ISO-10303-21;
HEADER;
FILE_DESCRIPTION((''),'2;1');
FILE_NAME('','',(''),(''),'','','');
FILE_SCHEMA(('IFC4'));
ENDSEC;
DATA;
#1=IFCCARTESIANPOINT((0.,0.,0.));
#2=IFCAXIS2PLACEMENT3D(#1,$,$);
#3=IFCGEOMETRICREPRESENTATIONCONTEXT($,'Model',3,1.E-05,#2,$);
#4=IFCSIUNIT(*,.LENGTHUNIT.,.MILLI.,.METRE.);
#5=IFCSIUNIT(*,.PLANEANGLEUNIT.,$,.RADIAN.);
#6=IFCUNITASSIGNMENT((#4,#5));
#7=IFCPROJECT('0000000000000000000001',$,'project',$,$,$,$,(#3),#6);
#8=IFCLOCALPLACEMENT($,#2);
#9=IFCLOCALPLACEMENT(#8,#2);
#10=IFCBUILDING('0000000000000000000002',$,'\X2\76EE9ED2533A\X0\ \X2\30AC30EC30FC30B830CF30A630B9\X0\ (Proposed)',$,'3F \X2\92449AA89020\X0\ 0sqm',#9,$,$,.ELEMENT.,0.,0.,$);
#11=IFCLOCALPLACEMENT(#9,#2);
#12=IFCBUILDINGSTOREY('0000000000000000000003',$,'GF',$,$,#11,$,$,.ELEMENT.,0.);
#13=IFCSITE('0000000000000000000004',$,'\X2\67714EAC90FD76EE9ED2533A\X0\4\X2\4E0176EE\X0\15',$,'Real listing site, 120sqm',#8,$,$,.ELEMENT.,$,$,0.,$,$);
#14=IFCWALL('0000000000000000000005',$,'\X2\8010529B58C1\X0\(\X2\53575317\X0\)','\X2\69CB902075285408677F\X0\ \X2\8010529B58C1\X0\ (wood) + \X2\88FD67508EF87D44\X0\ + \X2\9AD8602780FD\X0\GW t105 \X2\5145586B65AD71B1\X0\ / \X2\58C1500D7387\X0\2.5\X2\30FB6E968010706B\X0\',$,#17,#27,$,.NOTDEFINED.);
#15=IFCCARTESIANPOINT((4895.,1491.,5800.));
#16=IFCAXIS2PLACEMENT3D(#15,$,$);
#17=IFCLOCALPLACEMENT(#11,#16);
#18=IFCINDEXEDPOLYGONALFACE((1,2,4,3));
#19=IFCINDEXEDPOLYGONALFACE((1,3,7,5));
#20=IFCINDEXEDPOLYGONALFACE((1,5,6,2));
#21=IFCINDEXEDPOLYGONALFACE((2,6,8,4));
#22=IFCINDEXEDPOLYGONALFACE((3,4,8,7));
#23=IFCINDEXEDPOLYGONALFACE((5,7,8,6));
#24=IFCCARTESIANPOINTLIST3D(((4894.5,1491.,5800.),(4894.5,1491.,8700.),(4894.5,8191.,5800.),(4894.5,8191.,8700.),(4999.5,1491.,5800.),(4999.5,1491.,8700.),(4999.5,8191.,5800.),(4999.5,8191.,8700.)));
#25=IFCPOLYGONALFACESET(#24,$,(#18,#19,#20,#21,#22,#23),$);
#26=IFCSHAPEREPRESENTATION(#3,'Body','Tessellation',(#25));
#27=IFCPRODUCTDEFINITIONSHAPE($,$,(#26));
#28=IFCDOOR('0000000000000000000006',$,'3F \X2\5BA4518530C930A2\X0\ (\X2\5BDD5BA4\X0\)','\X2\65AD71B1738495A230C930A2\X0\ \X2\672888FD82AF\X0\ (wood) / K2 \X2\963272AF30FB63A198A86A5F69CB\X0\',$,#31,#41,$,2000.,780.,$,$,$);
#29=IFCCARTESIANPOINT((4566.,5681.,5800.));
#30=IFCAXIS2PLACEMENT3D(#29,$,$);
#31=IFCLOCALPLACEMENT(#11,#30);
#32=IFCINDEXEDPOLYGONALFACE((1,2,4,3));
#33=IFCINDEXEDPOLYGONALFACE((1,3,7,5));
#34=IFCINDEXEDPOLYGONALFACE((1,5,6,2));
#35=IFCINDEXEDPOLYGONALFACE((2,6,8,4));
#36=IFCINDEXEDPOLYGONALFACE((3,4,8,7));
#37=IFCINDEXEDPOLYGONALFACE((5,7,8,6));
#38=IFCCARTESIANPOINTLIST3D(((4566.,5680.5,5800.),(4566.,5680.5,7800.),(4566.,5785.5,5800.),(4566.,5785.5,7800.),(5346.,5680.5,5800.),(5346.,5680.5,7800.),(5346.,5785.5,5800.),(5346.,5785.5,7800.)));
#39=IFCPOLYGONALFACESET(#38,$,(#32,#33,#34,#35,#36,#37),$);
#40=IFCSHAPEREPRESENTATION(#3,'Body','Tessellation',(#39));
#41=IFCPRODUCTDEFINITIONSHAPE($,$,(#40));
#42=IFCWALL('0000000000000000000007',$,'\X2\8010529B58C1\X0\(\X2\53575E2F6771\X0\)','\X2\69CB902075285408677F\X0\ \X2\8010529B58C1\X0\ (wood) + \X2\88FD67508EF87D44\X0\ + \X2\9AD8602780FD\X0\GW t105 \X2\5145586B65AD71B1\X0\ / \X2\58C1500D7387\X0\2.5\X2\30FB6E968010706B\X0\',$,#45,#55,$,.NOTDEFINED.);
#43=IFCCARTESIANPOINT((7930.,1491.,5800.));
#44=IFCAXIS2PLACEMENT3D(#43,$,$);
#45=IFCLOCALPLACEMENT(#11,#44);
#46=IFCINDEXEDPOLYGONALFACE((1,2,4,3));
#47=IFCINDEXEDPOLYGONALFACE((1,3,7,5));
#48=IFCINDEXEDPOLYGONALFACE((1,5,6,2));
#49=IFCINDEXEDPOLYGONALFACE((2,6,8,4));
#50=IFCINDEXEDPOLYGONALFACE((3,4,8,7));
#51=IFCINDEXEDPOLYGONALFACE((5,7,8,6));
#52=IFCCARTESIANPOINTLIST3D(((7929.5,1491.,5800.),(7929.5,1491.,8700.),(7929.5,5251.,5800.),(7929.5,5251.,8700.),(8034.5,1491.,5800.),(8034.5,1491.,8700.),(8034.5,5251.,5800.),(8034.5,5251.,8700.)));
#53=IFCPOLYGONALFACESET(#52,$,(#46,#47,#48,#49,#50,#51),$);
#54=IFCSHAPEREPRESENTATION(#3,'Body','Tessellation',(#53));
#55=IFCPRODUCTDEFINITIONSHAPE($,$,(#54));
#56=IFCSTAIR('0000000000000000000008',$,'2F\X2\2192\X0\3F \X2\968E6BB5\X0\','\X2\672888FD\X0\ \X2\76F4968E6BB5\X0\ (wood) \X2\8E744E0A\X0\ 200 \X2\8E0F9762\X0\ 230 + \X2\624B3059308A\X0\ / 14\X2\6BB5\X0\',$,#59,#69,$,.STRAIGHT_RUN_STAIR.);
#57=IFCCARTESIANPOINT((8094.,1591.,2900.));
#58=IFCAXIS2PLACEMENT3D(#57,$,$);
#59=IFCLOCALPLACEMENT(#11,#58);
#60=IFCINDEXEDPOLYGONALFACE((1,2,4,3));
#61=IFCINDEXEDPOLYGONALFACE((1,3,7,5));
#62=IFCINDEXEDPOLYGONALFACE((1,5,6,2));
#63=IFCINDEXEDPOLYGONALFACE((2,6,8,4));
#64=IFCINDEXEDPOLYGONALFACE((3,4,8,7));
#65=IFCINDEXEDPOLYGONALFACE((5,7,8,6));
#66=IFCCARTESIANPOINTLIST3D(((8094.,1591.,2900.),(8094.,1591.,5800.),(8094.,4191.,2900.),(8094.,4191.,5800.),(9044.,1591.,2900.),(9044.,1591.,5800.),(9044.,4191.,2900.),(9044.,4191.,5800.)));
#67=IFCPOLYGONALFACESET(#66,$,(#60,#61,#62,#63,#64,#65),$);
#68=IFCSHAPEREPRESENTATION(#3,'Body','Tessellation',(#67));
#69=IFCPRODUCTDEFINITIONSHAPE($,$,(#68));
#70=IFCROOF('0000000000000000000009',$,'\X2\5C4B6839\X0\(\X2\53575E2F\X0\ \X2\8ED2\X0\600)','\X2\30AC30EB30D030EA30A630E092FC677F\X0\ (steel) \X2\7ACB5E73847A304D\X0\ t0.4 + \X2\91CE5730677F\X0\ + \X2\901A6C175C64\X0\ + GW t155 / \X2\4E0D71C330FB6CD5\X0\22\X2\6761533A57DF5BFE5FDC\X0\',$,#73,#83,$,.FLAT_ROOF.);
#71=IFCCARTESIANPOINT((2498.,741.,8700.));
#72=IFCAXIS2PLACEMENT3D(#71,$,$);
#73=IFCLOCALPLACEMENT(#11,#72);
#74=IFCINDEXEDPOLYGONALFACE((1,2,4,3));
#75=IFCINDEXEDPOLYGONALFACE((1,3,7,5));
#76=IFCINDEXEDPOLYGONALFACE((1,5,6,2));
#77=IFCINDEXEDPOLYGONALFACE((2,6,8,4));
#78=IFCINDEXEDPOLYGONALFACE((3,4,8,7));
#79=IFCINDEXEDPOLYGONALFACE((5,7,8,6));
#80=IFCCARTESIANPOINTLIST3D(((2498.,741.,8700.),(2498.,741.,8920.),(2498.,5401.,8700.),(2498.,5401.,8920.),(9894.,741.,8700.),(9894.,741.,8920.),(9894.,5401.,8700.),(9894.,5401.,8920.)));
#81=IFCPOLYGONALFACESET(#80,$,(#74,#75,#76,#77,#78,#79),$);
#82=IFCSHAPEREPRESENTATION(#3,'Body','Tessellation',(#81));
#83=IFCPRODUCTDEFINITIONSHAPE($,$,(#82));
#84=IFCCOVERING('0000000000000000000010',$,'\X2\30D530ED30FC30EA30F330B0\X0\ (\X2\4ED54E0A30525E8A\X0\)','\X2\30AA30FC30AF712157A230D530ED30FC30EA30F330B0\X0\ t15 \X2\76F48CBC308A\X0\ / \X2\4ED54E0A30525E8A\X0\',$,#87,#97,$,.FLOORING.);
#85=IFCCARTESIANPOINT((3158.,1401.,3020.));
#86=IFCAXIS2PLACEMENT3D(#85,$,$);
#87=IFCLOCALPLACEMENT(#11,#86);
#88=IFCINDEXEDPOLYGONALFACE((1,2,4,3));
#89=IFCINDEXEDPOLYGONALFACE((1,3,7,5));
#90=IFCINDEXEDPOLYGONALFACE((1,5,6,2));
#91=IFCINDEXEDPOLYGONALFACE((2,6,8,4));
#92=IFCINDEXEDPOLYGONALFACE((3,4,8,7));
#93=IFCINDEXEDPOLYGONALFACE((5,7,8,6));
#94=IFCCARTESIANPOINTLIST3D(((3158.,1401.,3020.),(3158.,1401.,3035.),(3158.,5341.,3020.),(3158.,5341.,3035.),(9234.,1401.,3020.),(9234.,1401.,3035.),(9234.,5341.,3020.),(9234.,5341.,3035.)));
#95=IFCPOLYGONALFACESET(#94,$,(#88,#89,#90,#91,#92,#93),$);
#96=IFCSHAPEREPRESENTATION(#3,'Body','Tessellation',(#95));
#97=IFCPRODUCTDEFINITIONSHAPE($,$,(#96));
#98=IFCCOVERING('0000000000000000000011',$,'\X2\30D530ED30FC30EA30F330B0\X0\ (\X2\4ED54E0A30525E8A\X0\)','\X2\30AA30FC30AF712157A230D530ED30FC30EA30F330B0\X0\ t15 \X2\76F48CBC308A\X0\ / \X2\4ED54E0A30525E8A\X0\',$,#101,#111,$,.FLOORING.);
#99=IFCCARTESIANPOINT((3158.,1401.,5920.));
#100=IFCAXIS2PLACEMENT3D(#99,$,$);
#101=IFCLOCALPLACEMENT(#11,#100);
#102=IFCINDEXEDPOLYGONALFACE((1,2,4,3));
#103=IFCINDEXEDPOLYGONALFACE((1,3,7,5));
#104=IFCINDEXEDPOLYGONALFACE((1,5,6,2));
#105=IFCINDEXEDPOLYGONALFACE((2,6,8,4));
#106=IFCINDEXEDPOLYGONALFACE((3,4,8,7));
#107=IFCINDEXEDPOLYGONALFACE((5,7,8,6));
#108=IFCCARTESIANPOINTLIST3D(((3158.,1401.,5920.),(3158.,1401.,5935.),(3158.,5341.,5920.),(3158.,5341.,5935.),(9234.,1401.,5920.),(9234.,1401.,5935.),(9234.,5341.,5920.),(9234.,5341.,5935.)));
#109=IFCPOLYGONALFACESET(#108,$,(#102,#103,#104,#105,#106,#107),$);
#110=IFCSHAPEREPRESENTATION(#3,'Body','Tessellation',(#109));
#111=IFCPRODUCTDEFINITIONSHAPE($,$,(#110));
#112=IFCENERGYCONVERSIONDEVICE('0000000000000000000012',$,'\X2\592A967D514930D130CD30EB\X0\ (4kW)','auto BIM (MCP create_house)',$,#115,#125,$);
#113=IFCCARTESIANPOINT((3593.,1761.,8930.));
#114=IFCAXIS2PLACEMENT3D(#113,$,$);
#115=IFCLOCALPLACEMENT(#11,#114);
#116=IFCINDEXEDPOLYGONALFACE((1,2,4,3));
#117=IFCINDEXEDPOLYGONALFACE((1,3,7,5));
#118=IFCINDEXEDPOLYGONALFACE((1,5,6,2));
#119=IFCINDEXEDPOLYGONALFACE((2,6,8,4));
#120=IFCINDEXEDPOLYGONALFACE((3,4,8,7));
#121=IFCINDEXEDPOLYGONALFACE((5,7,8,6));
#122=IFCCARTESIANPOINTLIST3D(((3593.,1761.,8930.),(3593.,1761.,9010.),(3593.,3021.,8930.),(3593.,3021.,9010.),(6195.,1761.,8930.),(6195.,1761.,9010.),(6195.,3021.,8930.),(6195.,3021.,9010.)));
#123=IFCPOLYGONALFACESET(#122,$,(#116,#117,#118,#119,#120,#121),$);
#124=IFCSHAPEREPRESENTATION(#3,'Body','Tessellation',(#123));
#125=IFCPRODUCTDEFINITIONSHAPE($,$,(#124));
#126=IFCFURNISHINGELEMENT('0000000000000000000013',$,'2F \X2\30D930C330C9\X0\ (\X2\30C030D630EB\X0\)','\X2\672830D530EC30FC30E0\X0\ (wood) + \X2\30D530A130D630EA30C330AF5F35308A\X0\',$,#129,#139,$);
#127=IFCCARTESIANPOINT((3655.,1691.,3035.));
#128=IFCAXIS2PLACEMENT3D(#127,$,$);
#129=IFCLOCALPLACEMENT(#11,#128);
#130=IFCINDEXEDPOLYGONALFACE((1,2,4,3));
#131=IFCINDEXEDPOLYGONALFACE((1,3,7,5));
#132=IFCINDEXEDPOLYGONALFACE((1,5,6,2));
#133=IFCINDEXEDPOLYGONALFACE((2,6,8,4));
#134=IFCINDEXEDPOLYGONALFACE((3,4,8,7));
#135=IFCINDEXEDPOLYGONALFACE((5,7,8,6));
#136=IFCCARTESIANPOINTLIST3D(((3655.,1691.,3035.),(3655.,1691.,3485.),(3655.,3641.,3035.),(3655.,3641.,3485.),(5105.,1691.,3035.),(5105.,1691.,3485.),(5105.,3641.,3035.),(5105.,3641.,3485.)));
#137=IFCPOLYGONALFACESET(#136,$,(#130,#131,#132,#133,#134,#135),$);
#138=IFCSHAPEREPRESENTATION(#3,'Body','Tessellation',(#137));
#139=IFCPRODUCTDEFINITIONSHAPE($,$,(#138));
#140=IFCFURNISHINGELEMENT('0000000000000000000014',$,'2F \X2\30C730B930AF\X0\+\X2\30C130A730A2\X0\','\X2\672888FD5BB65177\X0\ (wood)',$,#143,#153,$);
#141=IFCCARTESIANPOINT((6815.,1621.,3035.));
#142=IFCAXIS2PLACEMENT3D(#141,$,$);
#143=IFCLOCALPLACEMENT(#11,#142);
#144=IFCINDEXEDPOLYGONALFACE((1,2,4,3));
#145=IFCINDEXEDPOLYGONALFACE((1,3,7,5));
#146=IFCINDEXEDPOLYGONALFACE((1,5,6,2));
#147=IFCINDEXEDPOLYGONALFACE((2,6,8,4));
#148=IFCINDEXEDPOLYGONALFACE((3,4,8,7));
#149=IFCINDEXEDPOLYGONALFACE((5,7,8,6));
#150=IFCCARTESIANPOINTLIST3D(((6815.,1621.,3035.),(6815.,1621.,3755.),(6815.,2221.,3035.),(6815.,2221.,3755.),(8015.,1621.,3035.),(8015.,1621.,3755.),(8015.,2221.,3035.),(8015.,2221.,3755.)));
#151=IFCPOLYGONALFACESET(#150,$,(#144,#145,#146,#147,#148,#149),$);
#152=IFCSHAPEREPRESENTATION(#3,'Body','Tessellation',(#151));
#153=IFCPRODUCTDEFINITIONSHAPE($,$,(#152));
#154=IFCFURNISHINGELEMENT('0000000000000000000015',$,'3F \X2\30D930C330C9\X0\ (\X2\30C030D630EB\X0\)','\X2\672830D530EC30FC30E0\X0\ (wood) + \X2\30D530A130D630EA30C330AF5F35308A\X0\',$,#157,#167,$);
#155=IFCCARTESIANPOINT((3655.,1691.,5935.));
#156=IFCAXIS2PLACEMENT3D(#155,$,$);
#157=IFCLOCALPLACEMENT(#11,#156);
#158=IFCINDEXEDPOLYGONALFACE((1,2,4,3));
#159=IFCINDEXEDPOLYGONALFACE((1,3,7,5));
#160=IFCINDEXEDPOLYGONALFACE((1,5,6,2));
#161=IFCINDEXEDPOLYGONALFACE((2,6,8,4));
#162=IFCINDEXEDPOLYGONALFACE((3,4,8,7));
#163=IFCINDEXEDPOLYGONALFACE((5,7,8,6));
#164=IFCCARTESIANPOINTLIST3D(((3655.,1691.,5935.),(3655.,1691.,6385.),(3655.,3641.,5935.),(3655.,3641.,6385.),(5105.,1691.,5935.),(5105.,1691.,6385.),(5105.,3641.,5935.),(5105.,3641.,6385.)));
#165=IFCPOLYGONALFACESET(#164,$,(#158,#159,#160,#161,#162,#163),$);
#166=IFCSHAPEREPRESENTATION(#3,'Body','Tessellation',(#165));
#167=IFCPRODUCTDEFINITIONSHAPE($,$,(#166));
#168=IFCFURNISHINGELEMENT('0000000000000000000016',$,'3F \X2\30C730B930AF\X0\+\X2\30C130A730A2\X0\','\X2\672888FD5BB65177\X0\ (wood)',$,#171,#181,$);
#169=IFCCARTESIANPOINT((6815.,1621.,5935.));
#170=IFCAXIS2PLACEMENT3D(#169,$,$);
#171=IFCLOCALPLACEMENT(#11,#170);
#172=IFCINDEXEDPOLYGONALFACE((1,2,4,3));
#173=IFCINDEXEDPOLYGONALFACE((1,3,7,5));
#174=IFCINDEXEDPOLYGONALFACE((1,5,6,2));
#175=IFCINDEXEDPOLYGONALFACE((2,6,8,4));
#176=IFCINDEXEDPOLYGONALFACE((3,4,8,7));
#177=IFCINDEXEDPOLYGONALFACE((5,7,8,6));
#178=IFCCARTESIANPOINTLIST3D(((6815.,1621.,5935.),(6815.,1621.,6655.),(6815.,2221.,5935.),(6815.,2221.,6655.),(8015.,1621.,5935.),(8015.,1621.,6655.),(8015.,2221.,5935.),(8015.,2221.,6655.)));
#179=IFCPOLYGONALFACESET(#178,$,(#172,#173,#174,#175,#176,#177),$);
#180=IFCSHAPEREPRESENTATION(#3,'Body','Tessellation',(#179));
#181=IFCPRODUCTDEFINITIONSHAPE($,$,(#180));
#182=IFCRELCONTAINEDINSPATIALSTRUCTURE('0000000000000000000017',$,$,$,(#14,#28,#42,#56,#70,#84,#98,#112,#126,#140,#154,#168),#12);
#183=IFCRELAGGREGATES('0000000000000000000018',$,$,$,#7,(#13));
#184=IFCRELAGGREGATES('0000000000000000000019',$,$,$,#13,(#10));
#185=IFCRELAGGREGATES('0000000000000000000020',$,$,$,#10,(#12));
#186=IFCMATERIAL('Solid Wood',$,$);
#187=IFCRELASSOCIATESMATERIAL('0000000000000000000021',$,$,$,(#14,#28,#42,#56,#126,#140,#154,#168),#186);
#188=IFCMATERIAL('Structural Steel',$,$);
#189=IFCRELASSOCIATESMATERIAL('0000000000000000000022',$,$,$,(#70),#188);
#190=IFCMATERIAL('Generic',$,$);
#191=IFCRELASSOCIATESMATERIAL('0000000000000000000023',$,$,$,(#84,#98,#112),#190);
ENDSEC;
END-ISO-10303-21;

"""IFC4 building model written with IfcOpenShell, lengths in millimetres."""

from ifc_helpers import new_model, si_unit, frame, frame_2d, origin, place, context, project, spatial, rectangle, extrude, material, element, fill, save


model = new_model("IFC4")

# Units and contexts
model_context = context("Model", 3, precision=1e-05, world=origin())
ifc_project = project(units=[si_unit("LENGTHUNIT", "METRE", prefix="MILLI"), si_unit("PLANEANGLEUNIT", "RADIAN")], contexts=[model_context])

# Site, building, storey
site_placement = place(None, origin())
site = spatial("IfcSite", under=ifc_project, at=site_placement, Name="東京都目黒区4丁目15", ObjectType="Real listing site, 120sqm", CompositionType="ELEMENT", RefElevation=0.0)
building_placement = place(site_placement, origin())
building = spatial("IfcBuilding", under=site, at=building_placement, Name="目黒区 ガレージハウス (Proposed)", ObjectType="3F 鉄骨造 0sqm", CompositionType="ELEMENT", ElevationOfRefHeight=0.0, ElevationOfTerrain=0.0)
storey_placement = place(building_placement, origin())
storey = spatial("IfcBuildingStorey", under=building, at=storey_placement, Name="GF", CompositionType="ELEMENT", Elevation=0.0)

# Shared definitions
ifc_material_1 = material(Name="Solid Wood")

# Wall, opening, door
wall_1_placement = place(storey_placement, frame((4895.0, 1491.0, 5800.0)))
wall_1 = element("IfcWall", 1, at=wall_1_placement, inside=storey, material=ifc_material_1, Name="耐力壁(南北)", Description="構造用合板 耐力壁 (wood) + 製材軸組 + 高性能GW t105 充填断熱 / 壁倍率2.5・準耐火", PredefinedType="NOTDEFINED", context=model_context, shape_type="SweptSolid", body=[
    extrude(rectangle(XDim=105.0, YDim=6700.0, at=frame_2d((52.0, 3350.0))), frame((4895.0, 1491.0, 5800.0)), (0.0, 0.0, 1.0), 2900.0),
])
opening_1_placement = place(storey_placement, frame((4566.0, 5681.0, 5800.0)))
opening_1 = element("IfcOpeningElement", 2, at=opening_1_placement, cuts=wall_1, PredefinedType="NOTDEFINED", context=model_context, shape_type="SweptSolid", body=[
    extrude(rectangle(XDim=780.0, YDim=105.0, at=frame_2d((390.0, 52.0))), frame((4566.0, 5681.0, 5800.0)), (0.0, 0.0, 1.0), 2000.0),
])
door_1_placement = place(storey_placement, frame((4566.0, 5681.0, 5800.0)))
door_1 = element("IfcDoor", 3, at=door_1_placement, inside=storey, material=ifc_material_1, Name="3F 室内ドア (寝室)", Description="断熱玄関ドア 木製芯 (wood) / K2 防犯・採風機構", OverallHeight=2000.0, OverallWidth=780.0, context=model_context, shape_type="SweptSolid", body=[
    extrude(rectangle(XDim=780.0, YDim=105.0, at=frame_2d((390.0, 52.0))), frame((4566.0, 5681.0, 5800.0)), (0.0, 0.0, 1.0), 2000.0),
])
fill(opening_1, door_1)

# Wall
wall_2_placement = place(storey_placement, frame((7930.0, 1491.0, 5800.0)))
element("IfcWall", 4, at=wall_2_placement, inside=storey, material=ifc_material_1, Name="耐力壁(南帯東)", Description="構造用合板 耐力壁 (wood) + 製材軸組 + 高性能GW t105 充填断熱 / 壁倍率2.5・準耐火", PredefinedType="NOTDEFINED", context=model_context, shape_type="SweptSolid", body=[
    extrude(rectangle(XDim=105.0, YDim=3760.0, at=frame_2d((52.0, 1880.0))), frame((7930.0, 1491.0, 5800.0)), (0.0, 0.0, 1.0), 2900.0),
])

# Stair
stair_placement = place(storey_placement, frame((8094.0, 1591.0, 2900.0)))
element("IfcStair", 5, at=stair_placement, inside=storey, material=ifc_material_1, Name="2F→3F 階段", Description="木製 直階段 (wood) 蹴上 200 踏面 230 + 手すり / 14段", PredefinedType="STRAIGHT_RUN_STAIR", context=model_context, shape_type="SweptSolid", body=[
    extrude(rectangle(XDim=950.0, YDim=2600.0, at=frame_2d((475.0, 1300.0))), frame((8094.0, 1591.0, 2900.0)), (0.0, 0.0, 1.0), 2900.0),
])

# Roof
ifc_material_2 = material(Name="Structural Steel")
for number, where, name in (
    (6, (2498.0, 741.0, 8700.0), "屋根(南帯 軒600)"),
):
    element("IfcRoof", number, at=place(storey_placement, frame(where)), inside=storey, material=ifc_material_2, Name=name, Description="ガルバリウム鋼板 (steel) 立平葺き t0.4 + 野地板 + 通気層 + GW t155 / 不燃・法22条区域対応", PredefinedType="FLAT_ROOF", context=model_context, shape_type="SweptSolid", body=[
        extrude(rectangle(XDim=7396.0, YDim=4660.0, at=frame_2d((3698.0, 2330.0))), frame((2498.0, 741.0, 8700.0)), (0.0, 0.0, 1.0), 220.0),
    ])

# Coverings
ifc_material_3 = material(Name="Generic")
covering_1_placement = place(storey_placement, frame((3158.0, 1401.0, 3020.0)))
element("IfcCovering", 7, at=covering_1_placement, inside=storey, material=ifc_material_3, Name="フローリング (仕上げ床)", Description="オーク無垢フローリング t15 直貼り / 仕上げ床", PredefinedType="FLOORING", context=model_context, shape_type="SweptSolid", body=[
    extrude(rectangle(XDim=6076.0, YDim=3940.0, at=frame_2d((3038.0, 1970.0))), frame((3158.0, 1401.0, 3020.0)), (0.0, 0.0, 1.0), 15.0),
])
covering_2_placement = place(storey_placement, frame((3158.0, 1401.0, 5920.0)))
element("IfcCovering", 8, at=covering_2_placement, inside=storey, material=ifc_material_3, Name="フローリング (仕上げ床)", Description="オーク無垢フローリング t15 直貼り / 仕上げ床", PredefinedType="FLOORING", context=model_context, shape_type="SweptSolid", body=[
    extrude(rectangle(XDim=6076.0, YDim=3940.0, at=frame_2d((3038.0, 1970.0))), frame((3158.0, 1401.0, 5920.0)), (0.0, 0.0, 1.0), 15.0),
])

# Energy conversion device
energy_conversion_device_placement = place(storey_placement, frame((3593.0, 1761.0, 8930.0)))
element("IfcEnergyConversionDevice", 9, at=energy_conversion_device_placement, inside=storey, material=ifc_material_3, Name="太陽光パネル (4kW)", Description="auto BIM (MCP create_house)", context=model_context, shape_type="SweptSolid", body=[
    extrude(rectangle(XDim=2602.0, YDim=1260.0, at=frame_2d((1301.0, 630.0))), frame((3593.0, 1761.0, 8930.0)), (0.0, 0.0, 1.0), 80.0),
])

# Furnishing elements
furnishing_1_placement = place(storey_placement, frame((3655.0, 1691.0, 3035.0)))
element("IfcFurnishingElement", 10, at=furnishing_1_placement, inside=storey, material=ifc_material_1, Name="2F ベッド (ダブル)", Description="木フレーム (wood) + ファブリック張り", context=model_context, shape_type="SweptSolid", body=[
    extrude(rectangle(XDim=1450.0, YDim=1950.0, at=frame_2d((725.0, 975.0))), frame((3655.0, 1691.0, 3035.0)), (0.0, 0.0, 1.0), 450.0),
])
furnishing_2_placement = place(storey_placement, frame((6815.0, 1621.0, 3035.0)))
element("IfcFurnishingElement", 11, at=furnishing_2_placement, inside=storey, material=ifc_material_1, Name="2F デスク+チェア", Description="木製家具 (wood)", context=model_context, shape_type="SweptSolid", body=[
    extrude(rectangle(XDim=1200.0, YDim=600.0, at=frame_2d((600.0, 300.0))), frame((6815.0, 1621.0, 3035.0)), (0.0, 0.0, 1.0), 720.0),
])
furnishing_3_placement = place(storey_placement, frame((3655.0, 1691.0, 5935.0)))
element("IfcFurnishingElement", 12, at=furnishing_3_placement, inside=storey, material=ifc_material_1, Name="3F ベッド (ダブル)", Description="木フレーム (wood) + ファブリック張り", context=model_context, shape_type="SweptSolid", body=[
    extrude(rectangle(XDim=1450.0, YDim=1950.0, at=frame_2d((725.0, 975.0))), frame((3655.0, 1691.0, 5935.0)), (0.0, 0.0, 1.0), 450.0),
])
furnishing_4_placement = place(storey_placement, frame((6815.0, 1621.0, 5935.0)))
element("IfcFurnishingElement", 13, at=furnishing_4_placement, inside=storey, material=ifc_material_1, Name="3F デスク+チェア", Description="木製家具 (wood)", context=model_context, shape_type="SweptSolid", body=[
    extrude(rectangle(XDim=1200.0, YDim=600.0, at=frame_2d((600.0, 300.0))), frame((6815.0, 1621.0, 5935.0)), (0.0, 0.0, 1.0), 720.0),
])

save(model, "model.ifc")
